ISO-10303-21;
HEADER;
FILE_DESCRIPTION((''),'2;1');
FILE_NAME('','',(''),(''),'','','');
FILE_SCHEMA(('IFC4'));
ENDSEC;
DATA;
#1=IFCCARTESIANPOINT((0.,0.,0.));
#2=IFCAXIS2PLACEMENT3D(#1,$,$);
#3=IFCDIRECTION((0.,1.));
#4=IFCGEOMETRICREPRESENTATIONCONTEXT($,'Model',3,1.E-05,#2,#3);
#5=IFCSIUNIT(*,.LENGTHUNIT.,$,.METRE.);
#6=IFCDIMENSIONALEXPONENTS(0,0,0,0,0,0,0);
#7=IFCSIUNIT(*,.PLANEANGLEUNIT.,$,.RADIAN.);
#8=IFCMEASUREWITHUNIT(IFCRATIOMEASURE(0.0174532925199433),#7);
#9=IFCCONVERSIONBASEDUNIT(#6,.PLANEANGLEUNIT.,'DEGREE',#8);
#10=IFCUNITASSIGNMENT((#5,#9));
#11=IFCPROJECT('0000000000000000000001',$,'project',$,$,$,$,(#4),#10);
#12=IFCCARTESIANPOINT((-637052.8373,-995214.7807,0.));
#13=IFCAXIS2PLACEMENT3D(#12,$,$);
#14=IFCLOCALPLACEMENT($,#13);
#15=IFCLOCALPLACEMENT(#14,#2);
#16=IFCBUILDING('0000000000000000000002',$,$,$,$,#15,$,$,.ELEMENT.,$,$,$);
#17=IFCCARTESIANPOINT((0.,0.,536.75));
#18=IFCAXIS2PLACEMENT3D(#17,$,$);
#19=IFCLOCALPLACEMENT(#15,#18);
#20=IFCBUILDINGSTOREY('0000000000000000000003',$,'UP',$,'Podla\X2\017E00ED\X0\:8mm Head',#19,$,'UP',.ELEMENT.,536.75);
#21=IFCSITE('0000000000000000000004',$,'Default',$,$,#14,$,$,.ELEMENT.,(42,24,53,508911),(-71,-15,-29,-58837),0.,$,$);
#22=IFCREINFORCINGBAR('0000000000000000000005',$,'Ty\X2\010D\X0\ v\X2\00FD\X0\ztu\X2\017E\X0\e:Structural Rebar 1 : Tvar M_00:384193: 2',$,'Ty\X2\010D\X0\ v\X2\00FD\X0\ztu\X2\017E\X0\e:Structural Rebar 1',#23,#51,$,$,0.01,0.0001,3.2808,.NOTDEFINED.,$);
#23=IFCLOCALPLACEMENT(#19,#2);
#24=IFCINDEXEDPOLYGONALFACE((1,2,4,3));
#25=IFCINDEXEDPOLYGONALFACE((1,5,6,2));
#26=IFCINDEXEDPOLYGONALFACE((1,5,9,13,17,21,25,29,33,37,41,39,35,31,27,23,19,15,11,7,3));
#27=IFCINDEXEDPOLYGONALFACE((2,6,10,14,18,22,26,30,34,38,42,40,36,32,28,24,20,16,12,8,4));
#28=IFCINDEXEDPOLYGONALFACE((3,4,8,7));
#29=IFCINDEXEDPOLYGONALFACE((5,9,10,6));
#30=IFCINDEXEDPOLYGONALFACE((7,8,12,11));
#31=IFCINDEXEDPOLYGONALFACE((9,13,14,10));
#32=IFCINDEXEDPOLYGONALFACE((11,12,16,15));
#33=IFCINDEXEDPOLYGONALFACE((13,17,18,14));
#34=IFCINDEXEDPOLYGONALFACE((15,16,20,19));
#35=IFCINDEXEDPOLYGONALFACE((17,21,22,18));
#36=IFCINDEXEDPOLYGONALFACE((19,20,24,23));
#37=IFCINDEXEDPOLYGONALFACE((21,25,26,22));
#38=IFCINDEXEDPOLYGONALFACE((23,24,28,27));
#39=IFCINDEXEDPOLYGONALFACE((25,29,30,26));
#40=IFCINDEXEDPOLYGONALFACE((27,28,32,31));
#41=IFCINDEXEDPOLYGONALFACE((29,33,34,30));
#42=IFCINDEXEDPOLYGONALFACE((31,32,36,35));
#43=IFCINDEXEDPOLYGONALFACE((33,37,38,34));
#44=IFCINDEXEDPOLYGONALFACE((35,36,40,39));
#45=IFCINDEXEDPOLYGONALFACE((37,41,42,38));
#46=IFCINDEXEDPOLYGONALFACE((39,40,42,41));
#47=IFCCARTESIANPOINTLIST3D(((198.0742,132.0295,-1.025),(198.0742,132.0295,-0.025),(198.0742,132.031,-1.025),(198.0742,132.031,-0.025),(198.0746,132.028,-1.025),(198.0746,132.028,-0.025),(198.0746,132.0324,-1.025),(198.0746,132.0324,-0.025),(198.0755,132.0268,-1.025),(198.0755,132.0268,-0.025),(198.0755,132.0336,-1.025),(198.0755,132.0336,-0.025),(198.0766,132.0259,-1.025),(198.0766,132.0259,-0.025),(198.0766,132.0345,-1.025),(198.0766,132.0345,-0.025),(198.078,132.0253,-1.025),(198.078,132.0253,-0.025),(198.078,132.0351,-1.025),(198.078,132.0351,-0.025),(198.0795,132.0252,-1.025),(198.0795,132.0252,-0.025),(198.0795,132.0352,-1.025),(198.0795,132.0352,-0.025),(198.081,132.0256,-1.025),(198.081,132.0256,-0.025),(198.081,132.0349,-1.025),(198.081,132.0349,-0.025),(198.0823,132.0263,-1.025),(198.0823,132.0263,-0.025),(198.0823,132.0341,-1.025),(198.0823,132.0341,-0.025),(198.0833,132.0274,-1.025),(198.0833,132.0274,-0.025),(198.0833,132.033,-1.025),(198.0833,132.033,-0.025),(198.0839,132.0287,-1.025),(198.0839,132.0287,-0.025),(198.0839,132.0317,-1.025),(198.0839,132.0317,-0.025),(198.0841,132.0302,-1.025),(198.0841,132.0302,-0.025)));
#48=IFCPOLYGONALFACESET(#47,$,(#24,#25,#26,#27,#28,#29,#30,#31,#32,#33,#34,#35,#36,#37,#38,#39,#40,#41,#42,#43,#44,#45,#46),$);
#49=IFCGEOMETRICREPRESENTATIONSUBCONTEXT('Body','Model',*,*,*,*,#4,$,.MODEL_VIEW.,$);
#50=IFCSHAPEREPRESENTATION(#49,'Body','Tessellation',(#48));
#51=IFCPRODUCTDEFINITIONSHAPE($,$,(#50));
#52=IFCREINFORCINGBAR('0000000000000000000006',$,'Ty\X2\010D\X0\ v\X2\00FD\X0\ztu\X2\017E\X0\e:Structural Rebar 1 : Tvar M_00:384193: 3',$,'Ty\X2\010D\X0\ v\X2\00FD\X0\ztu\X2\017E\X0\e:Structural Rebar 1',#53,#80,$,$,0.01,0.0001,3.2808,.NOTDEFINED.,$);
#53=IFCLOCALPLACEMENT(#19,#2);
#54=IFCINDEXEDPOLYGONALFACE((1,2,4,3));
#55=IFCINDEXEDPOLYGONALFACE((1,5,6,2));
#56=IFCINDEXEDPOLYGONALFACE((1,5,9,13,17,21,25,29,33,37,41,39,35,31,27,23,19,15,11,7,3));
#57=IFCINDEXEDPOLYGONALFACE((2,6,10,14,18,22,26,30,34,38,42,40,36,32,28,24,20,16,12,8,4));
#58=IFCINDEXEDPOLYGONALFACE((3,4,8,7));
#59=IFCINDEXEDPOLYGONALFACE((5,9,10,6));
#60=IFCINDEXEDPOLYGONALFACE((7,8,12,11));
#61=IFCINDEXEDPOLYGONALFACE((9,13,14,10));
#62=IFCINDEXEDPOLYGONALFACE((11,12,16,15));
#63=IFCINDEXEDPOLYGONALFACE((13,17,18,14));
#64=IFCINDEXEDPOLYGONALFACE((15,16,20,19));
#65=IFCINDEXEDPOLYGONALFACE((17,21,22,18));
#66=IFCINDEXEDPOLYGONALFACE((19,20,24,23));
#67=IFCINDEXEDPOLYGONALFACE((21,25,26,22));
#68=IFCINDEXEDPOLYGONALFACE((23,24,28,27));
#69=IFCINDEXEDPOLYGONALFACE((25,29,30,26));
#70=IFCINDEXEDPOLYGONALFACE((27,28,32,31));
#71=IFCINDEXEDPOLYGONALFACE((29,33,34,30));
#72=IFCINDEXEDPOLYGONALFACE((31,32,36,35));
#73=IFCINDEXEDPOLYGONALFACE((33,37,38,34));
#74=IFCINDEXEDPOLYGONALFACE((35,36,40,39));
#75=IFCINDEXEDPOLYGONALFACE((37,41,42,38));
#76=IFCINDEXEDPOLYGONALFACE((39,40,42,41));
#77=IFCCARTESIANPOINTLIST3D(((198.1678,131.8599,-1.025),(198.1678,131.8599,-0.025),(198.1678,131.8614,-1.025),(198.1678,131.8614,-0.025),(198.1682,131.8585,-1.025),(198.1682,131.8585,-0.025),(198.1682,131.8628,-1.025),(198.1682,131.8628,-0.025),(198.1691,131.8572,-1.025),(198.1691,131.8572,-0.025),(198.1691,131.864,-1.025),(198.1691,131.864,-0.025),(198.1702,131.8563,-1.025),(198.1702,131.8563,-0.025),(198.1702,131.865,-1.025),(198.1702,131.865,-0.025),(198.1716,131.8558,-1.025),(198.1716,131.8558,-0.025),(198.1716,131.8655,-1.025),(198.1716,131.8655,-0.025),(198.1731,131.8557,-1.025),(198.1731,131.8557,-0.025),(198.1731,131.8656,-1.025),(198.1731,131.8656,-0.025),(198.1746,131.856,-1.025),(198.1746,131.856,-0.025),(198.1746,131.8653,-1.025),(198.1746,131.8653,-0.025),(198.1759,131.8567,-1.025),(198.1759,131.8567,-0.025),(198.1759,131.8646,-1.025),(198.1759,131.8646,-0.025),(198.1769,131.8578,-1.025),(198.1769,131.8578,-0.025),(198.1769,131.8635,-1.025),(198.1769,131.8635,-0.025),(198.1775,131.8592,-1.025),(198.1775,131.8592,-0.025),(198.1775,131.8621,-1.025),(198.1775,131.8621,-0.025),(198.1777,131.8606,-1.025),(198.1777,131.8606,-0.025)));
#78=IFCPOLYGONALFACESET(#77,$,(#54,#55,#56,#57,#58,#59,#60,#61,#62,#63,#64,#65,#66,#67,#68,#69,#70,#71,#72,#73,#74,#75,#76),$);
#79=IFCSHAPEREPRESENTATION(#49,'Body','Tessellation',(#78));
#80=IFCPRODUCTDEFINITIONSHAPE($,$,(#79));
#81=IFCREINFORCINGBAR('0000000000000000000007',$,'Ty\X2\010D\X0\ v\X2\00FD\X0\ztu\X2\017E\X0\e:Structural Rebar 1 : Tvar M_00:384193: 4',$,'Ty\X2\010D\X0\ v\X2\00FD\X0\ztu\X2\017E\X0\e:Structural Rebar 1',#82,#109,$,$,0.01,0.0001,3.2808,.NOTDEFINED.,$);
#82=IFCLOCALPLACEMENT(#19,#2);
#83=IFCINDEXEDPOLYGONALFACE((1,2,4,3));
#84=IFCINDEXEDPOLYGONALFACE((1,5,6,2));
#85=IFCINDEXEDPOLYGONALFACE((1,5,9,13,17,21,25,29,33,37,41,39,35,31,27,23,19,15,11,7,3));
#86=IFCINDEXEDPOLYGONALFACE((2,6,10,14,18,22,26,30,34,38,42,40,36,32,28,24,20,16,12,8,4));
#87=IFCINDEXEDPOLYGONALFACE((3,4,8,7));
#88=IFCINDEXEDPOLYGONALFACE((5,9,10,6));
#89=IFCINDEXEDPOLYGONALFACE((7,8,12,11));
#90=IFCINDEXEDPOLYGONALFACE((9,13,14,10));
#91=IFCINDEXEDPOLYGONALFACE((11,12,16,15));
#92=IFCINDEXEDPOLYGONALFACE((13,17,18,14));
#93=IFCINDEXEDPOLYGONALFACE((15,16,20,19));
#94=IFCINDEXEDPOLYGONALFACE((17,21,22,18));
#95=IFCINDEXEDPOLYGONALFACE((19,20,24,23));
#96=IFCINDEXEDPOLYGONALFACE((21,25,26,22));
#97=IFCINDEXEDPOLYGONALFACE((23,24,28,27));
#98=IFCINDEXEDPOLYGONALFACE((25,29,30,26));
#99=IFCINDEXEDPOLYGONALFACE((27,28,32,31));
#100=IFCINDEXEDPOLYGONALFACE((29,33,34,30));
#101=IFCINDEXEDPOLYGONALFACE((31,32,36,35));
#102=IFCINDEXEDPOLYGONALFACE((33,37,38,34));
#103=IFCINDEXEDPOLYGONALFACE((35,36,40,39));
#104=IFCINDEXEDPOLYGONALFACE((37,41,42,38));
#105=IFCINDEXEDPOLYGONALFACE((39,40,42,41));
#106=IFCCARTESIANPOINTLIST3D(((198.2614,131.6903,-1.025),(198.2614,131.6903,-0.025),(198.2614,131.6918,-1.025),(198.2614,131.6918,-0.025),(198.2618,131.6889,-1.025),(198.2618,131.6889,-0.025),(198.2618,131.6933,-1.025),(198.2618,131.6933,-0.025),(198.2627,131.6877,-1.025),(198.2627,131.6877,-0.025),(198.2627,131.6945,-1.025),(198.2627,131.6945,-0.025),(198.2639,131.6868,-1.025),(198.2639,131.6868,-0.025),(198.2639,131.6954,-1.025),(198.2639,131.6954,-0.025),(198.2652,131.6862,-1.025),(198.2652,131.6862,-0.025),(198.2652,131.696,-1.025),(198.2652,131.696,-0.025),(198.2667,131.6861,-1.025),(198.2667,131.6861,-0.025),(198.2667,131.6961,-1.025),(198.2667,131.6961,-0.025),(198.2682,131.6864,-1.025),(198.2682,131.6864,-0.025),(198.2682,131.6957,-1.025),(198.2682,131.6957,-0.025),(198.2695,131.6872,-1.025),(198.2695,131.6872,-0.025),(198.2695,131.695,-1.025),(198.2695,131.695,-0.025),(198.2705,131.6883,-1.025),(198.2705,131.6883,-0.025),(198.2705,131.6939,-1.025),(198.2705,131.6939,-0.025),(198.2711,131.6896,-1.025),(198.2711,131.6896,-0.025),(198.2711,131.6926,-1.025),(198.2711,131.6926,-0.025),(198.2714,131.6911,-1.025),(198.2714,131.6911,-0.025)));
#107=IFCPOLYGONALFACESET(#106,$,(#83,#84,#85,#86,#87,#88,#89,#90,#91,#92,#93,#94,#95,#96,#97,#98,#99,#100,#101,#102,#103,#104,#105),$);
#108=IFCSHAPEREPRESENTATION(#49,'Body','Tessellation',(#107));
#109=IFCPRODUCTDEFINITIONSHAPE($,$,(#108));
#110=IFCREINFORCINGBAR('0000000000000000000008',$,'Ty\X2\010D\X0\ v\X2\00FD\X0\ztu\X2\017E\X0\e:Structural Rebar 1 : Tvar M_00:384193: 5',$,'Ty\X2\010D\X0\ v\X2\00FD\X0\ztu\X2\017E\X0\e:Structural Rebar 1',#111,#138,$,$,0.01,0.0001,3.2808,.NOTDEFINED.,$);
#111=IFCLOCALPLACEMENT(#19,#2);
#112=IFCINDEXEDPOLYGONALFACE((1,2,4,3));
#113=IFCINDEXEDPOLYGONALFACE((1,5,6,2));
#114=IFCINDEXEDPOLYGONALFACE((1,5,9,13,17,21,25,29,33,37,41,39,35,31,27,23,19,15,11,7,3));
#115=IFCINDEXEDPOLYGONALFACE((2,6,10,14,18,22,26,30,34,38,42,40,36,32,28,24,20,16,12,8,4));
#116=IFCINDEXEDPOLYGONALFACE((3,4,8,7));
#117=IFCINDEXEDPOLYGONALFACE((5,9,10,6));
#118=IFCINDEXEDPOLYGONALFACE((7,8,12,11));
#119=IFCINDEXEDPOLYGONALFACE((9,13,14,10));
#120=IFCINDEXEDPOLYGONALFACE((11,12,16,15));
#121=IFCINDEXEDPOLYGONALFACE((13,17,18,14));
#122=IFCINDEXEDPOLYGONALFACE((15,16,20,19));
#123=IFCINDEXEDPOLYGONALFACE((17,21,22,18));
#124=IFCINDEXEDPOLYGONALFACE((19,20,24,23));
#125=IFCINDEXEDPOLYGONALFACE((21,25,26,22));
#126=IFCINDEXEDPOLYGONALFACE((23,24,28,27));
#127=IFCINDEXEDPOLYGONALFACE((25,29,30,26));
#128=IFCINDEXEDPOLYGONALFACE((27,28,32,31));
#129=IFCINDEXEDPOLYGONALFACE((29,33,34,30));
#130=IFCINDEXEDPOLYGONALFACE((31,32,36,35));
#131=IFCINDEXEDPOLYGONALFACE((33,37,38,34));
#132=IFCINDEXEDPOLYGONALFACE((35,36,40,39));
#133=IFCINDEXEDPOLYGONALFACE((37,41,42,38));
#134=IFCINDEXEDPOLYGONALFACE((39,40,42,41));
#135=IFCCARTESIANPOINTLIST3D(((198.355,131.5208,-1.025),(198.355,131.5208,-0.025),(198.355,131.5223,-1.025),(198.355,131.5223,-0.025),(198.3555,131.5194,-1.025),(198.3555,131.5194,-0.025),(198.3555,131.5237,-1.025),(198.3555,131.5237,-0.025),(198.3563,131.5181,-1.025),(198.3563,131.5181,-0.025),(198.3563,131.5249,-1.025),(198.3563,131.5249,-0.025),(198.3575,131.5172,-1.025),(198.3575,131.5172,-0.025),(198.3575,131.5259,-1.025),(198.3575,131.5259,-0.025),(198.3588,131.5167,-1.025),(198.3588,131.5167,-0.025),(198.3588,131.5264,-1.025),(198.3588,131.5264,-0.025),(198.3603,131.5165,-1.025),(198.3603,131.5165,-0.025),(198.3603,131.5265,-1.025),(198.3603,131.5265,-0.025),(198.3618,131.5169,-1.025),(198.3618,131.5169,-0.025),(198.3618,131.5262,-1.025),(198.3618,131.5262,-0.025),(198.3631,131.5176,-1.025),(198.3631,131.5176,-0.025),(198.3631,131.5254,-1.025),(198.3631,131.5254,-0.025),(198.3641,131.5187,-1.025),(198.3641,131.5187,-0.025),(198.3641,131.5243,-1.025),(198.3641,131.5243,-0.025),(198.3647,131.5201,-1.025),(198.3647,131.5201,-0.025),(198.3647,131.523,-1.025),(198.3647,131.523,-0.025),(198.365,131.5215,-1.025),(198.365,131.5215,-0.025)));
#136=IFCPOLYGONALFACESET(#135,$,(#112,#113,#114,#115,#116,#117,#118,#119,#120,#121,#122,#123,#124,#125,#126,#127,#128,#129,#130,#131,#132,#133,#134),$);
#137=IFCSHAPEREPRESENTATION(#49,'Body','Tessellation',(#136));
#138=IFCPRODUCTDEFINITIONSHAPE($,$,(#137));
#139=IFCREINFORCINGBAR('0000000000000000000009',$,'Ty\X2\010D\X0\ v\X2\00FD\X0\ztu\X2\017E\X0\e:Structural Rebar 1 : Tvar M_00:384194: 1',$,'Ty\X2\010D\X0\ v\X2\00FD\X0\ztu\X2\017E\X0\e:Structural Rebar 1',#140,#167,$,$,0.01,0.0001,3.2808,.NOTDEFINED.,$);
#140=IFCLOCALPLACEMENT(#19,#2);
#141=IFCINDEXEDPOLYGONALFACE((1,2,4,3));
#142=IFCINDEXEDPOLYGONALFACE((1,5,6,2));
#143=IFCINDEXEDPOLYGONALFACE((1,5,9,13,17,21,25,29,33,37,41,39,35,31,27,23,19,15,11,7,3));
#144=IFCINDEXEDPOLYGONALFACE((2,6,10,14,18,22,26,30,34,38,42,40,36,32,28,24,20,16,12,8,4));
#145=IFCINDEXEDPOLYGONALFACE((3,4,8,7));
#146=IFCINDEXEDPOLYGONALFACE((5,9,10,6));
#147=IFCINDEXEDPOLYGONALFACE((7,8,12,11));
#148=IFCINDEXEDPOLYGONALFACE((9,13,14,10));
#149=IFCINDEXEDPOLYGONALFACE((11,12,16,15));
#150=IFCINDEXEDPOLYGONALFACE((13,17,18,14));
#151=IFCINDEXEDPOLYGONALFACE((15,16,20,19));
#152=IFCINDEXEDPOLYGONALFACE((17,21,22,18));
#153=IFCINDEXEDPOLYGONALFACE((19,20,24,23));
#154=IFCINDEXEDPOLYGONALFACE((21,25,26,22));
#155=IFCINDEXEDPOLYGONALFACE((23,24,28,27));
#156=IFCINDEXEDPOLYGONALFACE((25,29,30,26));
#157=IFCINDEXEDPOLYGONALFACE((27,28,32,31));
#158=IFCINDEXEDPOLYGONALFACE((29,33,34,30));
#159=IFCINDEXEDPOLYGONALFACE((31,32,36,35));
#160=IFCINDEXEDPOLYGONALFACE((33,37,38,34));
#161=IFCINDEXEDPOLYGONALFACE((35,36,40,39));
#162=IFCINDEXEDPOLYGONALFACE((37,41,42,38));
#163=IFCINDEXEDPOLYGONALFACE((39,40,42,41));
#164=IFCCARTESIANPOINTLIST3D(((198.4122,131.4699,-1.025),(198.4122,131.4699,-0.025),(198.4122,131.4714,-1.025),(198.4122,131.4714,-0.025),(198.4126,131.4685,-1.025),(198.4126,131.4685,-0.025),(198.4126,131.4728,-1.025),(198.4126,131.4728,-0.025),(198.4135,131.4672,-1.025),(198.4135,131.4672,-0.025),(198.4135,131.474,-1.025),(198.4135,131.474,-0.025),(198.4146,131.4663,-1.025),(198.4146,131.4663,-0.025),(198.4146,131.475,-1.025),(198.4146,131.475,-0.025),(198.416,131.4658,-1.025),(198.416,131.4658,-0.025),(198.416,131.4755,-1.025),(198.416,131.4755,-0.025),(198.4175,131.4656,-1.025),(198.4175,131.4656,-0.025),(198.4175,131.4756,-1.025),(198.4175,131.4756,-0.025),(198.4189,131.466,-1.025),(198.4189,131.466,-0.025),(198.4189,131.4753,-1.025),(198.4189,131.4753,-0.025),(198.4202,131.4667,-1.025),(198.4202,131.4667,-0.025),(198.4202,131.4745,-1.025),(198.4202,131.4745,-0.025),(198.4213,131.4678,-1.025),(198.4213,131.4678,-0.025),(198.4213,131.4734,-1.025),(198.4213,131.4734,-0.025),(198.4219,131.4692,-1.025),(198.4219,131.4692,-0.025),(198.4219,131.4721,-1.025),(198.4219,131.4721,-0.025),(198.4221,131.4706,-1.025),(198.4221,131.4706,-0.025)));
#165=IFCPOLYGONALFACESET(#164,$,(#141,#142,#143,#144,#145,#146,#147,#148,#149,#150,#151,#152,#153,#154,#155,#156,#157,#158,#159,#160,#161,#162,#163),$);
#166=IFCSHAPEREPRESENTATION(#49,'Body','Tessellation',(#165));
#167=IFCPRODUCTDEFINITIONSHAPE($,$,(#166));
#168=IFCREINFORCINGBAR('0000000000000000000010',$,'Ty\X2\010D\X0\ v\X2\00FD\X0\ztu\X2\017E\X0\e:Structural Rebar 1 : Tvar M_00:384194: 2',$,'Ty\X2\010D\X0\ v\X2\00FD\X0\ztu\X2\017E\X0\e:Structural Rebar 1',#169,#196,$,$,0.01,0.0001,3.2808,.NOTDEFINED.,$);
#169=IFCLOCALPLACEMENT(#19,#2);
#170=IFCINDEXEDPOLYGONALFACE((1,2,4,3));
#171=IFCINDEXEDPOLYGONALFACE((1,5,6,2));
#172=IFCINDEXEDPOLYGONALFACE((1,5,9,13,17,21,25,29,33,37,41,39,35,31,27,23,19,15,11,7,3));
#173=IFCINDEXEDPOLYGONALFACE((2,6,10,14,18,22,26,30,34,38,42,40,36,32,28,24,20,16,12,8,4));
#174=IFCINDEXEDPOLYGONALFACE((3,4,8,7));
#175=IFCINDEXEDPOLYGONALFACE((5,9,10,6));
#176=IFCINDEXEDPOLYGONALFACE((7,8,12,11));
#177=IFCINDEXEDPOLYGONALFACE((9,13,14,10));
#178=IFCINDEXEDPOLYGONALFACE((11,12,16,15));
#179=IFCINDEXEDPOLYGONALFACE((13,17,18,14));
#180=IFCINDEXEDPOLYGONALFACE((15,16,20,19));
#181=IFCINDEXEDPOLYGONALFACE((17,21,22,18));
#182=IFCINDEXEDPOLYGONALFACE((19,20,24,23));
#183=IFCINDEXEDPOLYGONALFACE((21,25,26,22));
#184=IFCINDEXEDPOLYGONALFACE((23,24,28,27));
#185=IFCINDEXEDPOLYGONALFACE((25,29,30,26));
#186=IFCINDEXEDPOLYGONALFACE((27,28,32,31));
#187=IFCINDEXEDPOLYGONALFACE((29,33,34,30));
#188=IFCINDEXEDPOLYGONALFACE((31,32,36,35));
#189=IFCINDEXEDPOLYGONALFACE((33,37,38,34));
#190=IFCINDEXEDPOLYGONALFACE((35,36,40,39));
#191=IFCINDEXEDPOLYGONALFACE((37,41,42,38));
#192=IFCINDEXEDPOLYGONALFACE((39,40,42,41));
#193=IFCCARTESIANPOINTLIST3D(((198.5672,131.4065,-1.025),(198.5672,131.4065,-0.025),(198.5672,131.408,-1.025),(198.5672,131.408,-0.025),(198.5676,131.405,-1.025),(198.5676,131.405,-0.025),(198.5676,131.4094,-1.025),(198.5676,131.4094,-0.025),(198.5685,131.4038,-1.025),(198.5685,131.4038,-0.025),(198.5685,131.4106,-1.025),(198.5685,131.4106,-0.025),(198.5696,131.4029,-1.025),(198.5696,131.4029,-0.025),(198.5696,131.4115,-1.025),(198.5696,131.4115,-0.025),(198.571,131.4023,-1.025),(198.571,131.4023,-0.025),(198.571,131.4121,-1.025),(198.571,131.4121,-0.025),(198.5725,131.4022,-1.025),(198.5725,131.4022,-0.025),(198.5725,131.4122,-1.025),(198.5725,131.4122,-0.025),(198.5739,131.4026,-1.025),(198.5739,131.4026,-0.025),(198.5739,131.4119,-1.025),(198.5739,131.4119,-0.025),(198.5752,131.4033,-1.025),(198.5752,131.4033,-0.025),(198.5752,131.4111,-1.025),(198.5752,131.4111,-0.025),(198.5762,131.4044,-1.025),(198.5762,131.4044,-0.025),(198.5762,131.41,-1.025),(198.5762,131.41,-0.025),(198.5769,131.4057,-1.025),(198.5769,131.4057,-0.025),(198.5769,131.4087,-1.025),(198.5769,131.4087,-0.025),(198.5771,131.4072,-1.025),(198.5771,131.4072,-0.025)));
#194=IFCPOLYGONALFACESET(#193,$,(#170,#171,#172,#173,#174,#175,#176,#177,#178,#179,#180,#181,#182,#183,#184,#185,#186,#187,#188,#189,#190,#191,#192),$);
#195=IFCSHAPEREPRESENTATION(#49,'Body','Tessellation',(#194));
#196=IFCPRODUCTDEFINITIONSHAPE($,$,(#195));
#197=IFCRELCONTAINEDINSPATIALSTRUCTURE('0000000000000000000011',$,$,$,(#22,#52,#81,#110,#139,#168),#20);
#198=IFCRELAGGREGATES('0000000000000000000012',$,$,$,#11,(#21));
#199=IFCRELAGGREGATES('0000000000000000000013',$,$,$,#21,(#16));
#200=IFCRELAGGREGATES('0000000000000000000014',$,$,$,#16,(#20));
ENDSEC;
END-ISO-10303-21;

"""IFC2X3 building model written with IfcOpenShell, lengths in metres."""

from ifc_helpers import new_model, entity, si_unit, converted_unit, direction, frame, origin, place, context, subcontext, project, spatial, element, save


model = new_model("IFC2X3")

# Units and contexts
model_context = context("Model", 3, precision=1e-05, world=origin(), true_north=direction((0.0, 1.0)))
body_context = subcontext(model_context, "Body", "Model", "MODEL_VIEW")
ifc_project = project(units=[si_unit("LENGTHUNIT", "METRE"), converted_unit("PLANEANGLEUNIT", "DEGREE", entity("IfcRatioMeasure", 0.0174532925199433), si_unit("PLANEANGLEUNIT", "RADIAN"), dimensions=[0, 0, 0, 0, 0, 0, 0])], contexts=[model_context])

# Site, building, storey
site_placement = place(None, frame((-637052.8373, -995214.7807, 0.0)))
site = spatial("IfcSite", under=ifc_project, at=site_placement, Name="Default", CompositionType="ELEMENT", RefLatitude=(42, 24, 53, 508911), RefLongitude=(-71, -15, -29, -58837), RefElevation=0.0)
building_placement = place(site_placement, origin())
building = spatial("IfcBuilding", under=site, at=building_placement, CompositionType="ELEMENT")
storey_placement = place(building_placement, frame((0.0, 0.0, 536.75)))
storey = spatial("IfcBuildingStorey", under=building, at=storey_placement, Name="UP", ObjectType="Podlaží:8mm Head", LongName="UP", CompositionType="ELEMENT", Elevation=536.75)

# Reinforcing bars
reinforcing_bar_1_placement = place(storey_placement, origin())
element("IfcReinforcingBar", 1, at=reinforcing_bar_1_placement, inside=storey, Name="Tyč výztuže:Structural Rebar 1 : Tvar M_00:384193: 2", ObjectType="Tyč výztuže:Structural Rebar 1", BarLength=3.2808, BarRole="NOTDEFINED", CrossSectionArea=0.0001, NominalDiameter=0.01, context=body_context, shape_type="AdvancedSweptSolid", body=[
    entity("IfcSweptDiskSolid", entity("IfcCompositeCurve", [entity("IfcCompositeCurveSegment", "CONTINUOUS", True, entity("IfcPolyline", [entity("IfcCartesianPoint", [-198.0791, -132.0302, 0.025]), entity("IfcCartesianPoint", [-198.0791, -132.0302, 1.025])]))], False), 0.005, None, 0.0, 1.0),
])
reinforcing_bar_2_placement = place(storey_placement, origin())
element("IfcReinforcingBar", 2, at=reinforcing_bar_2_placement, inside=storey, Name="Tyč výztuže:Structural Rebar 1 : Tvar M_00:384193: 3", ObjectType="Tyč výztuže:Structural Rebar 1", BarLength=3.2808, BarRole="NOTDEFINED", CrossSectionArea=0.0001, NominalDiameter=0.01, context=body_context, shape_type="AdvancedSweptSolid", body=[
    entity("IfcSweptDiskSolid", entity("IfcCompositeCurve", [entity("IfcCompositeCurveSegment", "CONTINUOUS", True, entity("IfcPolyline", [entity("IfcCartesianPoint", [-198.1727, -131.8606, 0.025]), entity("IfcCartesianPoint", [-198.1727, -131.8606, 1.025])]))], False), 0.005, None, 0.0, 1.0),
])
reinforcing_bar_3_placement = place(storey_placement, origin())
element("IfcReinforcingBar", 3, at=reinforcing_bar_3_placement, inside=storey, Name="Tyč výztuže:Structural Rebar 1 : Tvar M_00:384193: 4", ObjectType="Tyč výztuže:Structural Rebar 1", BarLength=3.2808, BarRole="NOTDEFINED", CrossSectionArea=0.0001, NominalDiameter=0.01, context=body_context, shape_type="AdvancedSweptSolid", body=[
    entity("IfcSweptDiskSolid", entity("IfcCompositeCurve", [entity("IfcCompositeCurveSegment", "CONTINUOUS", True, entity("IfcPolyline", [entity("IfcCartesianPoint", [-198.2664, -131.6911, 0.025]), entity("IfcCartesianPoint", [-198.2664, -131.6911, 1.025])]))], False), 0.005, None, 0.0, 1.0),
])
reinforcing_bar_4_placement = place(storey_placement, origin())
element("IfcReinforcingBar", 4, at=reinforcing_bar_4_placement, inside=storey, Name="Tyč výztuže:Structural Rebar 1 : Tvar M_00:384193: 5", ObjectType="Tyč výztuže:Structural Rebar 1", BarLength=3.2808, BarRole="NOTDEFINED", CrossSectionArea=0.0001, NominalDiameter=0.01, context=body_context, shape_type="AdvancedSweptSolid", body=[
    entity("IfcSweptDiskSolid", entity("IfcCompositeCurve", [entity("IfcCompositeCurveSegment", "CONTINUOUS", True, entity("IfcPolyline", [entity("IfcCartesianPoint", [-198.36, -131.5215, 0.025]), entity("IfcCartesianPoint", [-198.36, -131.5215, 1.025])]))], False), 0.005, None, 0.0, 1.0),
])
reinforcing_bar_5_placement = place(storey_placement, origin())
element("IfcReinforcingBar", 5, at=reinforcing_bar_5_placement, inside=storey, Name="Tyč výztuže:Structural Rebar 1 : Tvar M_00:384194: 1", ObjectType="Tyč výztuže:Structural Rebar 1", BarLength=3.2808, BarRole="NOTDEFINED", CrossSectionArea=0.0001, NominalDiameter=0.01, context=body_context, shape_type="AdvancedSweptSolid", body=[
    entity("IfcSweptDiskSolid", entity("IfcCompositeCurve", [entity("IfcCompositeCurveSegment", "CONTINUOUS", True, entity("IfcPolyline", [entity("IfcCartesianPoint", [-198.4171, -131.4706, 0.025]), entity("IfcCartesianPoint", [-198.4171, -131.4706, 1.025])]))], False), 0.005, None, 0.0, 1.0),
])
reinforcing_bar_6_placement = place(storey_placement, origin())
element("IfcReinforcingBar", 6, at=reinforcing_bar_6_placement, inside=storey, Name="Tyč výztuže:Structural Rebar 1 : Tvar M_00:384194: 2", ObjectType="Tyč výztuže:Structural Rebar 1", BarLength=3.2808, BarRole="NOTDEFINED", CrossSectionArea=0.0001, NominalDiameter=0.01, context=body_context, shape_type="AdvancedSweptSolid", body=[
    entity("IfcSweptDiskSolid", entity("IfcCompositeCurve", [entity("IfcCompositeCurveSegment", "CONTINUOUS", True, entity("IfcPolyline", [entity("IfcCartesianPoint", [-198.5721, -131.4072, 0.025]), entity("IfcCartesianPoint", [-198.5721, -131.4072, 1.025])]))], False), 0.005, None, 0.0, 1.0),
])

save(model, "model.ifc")
